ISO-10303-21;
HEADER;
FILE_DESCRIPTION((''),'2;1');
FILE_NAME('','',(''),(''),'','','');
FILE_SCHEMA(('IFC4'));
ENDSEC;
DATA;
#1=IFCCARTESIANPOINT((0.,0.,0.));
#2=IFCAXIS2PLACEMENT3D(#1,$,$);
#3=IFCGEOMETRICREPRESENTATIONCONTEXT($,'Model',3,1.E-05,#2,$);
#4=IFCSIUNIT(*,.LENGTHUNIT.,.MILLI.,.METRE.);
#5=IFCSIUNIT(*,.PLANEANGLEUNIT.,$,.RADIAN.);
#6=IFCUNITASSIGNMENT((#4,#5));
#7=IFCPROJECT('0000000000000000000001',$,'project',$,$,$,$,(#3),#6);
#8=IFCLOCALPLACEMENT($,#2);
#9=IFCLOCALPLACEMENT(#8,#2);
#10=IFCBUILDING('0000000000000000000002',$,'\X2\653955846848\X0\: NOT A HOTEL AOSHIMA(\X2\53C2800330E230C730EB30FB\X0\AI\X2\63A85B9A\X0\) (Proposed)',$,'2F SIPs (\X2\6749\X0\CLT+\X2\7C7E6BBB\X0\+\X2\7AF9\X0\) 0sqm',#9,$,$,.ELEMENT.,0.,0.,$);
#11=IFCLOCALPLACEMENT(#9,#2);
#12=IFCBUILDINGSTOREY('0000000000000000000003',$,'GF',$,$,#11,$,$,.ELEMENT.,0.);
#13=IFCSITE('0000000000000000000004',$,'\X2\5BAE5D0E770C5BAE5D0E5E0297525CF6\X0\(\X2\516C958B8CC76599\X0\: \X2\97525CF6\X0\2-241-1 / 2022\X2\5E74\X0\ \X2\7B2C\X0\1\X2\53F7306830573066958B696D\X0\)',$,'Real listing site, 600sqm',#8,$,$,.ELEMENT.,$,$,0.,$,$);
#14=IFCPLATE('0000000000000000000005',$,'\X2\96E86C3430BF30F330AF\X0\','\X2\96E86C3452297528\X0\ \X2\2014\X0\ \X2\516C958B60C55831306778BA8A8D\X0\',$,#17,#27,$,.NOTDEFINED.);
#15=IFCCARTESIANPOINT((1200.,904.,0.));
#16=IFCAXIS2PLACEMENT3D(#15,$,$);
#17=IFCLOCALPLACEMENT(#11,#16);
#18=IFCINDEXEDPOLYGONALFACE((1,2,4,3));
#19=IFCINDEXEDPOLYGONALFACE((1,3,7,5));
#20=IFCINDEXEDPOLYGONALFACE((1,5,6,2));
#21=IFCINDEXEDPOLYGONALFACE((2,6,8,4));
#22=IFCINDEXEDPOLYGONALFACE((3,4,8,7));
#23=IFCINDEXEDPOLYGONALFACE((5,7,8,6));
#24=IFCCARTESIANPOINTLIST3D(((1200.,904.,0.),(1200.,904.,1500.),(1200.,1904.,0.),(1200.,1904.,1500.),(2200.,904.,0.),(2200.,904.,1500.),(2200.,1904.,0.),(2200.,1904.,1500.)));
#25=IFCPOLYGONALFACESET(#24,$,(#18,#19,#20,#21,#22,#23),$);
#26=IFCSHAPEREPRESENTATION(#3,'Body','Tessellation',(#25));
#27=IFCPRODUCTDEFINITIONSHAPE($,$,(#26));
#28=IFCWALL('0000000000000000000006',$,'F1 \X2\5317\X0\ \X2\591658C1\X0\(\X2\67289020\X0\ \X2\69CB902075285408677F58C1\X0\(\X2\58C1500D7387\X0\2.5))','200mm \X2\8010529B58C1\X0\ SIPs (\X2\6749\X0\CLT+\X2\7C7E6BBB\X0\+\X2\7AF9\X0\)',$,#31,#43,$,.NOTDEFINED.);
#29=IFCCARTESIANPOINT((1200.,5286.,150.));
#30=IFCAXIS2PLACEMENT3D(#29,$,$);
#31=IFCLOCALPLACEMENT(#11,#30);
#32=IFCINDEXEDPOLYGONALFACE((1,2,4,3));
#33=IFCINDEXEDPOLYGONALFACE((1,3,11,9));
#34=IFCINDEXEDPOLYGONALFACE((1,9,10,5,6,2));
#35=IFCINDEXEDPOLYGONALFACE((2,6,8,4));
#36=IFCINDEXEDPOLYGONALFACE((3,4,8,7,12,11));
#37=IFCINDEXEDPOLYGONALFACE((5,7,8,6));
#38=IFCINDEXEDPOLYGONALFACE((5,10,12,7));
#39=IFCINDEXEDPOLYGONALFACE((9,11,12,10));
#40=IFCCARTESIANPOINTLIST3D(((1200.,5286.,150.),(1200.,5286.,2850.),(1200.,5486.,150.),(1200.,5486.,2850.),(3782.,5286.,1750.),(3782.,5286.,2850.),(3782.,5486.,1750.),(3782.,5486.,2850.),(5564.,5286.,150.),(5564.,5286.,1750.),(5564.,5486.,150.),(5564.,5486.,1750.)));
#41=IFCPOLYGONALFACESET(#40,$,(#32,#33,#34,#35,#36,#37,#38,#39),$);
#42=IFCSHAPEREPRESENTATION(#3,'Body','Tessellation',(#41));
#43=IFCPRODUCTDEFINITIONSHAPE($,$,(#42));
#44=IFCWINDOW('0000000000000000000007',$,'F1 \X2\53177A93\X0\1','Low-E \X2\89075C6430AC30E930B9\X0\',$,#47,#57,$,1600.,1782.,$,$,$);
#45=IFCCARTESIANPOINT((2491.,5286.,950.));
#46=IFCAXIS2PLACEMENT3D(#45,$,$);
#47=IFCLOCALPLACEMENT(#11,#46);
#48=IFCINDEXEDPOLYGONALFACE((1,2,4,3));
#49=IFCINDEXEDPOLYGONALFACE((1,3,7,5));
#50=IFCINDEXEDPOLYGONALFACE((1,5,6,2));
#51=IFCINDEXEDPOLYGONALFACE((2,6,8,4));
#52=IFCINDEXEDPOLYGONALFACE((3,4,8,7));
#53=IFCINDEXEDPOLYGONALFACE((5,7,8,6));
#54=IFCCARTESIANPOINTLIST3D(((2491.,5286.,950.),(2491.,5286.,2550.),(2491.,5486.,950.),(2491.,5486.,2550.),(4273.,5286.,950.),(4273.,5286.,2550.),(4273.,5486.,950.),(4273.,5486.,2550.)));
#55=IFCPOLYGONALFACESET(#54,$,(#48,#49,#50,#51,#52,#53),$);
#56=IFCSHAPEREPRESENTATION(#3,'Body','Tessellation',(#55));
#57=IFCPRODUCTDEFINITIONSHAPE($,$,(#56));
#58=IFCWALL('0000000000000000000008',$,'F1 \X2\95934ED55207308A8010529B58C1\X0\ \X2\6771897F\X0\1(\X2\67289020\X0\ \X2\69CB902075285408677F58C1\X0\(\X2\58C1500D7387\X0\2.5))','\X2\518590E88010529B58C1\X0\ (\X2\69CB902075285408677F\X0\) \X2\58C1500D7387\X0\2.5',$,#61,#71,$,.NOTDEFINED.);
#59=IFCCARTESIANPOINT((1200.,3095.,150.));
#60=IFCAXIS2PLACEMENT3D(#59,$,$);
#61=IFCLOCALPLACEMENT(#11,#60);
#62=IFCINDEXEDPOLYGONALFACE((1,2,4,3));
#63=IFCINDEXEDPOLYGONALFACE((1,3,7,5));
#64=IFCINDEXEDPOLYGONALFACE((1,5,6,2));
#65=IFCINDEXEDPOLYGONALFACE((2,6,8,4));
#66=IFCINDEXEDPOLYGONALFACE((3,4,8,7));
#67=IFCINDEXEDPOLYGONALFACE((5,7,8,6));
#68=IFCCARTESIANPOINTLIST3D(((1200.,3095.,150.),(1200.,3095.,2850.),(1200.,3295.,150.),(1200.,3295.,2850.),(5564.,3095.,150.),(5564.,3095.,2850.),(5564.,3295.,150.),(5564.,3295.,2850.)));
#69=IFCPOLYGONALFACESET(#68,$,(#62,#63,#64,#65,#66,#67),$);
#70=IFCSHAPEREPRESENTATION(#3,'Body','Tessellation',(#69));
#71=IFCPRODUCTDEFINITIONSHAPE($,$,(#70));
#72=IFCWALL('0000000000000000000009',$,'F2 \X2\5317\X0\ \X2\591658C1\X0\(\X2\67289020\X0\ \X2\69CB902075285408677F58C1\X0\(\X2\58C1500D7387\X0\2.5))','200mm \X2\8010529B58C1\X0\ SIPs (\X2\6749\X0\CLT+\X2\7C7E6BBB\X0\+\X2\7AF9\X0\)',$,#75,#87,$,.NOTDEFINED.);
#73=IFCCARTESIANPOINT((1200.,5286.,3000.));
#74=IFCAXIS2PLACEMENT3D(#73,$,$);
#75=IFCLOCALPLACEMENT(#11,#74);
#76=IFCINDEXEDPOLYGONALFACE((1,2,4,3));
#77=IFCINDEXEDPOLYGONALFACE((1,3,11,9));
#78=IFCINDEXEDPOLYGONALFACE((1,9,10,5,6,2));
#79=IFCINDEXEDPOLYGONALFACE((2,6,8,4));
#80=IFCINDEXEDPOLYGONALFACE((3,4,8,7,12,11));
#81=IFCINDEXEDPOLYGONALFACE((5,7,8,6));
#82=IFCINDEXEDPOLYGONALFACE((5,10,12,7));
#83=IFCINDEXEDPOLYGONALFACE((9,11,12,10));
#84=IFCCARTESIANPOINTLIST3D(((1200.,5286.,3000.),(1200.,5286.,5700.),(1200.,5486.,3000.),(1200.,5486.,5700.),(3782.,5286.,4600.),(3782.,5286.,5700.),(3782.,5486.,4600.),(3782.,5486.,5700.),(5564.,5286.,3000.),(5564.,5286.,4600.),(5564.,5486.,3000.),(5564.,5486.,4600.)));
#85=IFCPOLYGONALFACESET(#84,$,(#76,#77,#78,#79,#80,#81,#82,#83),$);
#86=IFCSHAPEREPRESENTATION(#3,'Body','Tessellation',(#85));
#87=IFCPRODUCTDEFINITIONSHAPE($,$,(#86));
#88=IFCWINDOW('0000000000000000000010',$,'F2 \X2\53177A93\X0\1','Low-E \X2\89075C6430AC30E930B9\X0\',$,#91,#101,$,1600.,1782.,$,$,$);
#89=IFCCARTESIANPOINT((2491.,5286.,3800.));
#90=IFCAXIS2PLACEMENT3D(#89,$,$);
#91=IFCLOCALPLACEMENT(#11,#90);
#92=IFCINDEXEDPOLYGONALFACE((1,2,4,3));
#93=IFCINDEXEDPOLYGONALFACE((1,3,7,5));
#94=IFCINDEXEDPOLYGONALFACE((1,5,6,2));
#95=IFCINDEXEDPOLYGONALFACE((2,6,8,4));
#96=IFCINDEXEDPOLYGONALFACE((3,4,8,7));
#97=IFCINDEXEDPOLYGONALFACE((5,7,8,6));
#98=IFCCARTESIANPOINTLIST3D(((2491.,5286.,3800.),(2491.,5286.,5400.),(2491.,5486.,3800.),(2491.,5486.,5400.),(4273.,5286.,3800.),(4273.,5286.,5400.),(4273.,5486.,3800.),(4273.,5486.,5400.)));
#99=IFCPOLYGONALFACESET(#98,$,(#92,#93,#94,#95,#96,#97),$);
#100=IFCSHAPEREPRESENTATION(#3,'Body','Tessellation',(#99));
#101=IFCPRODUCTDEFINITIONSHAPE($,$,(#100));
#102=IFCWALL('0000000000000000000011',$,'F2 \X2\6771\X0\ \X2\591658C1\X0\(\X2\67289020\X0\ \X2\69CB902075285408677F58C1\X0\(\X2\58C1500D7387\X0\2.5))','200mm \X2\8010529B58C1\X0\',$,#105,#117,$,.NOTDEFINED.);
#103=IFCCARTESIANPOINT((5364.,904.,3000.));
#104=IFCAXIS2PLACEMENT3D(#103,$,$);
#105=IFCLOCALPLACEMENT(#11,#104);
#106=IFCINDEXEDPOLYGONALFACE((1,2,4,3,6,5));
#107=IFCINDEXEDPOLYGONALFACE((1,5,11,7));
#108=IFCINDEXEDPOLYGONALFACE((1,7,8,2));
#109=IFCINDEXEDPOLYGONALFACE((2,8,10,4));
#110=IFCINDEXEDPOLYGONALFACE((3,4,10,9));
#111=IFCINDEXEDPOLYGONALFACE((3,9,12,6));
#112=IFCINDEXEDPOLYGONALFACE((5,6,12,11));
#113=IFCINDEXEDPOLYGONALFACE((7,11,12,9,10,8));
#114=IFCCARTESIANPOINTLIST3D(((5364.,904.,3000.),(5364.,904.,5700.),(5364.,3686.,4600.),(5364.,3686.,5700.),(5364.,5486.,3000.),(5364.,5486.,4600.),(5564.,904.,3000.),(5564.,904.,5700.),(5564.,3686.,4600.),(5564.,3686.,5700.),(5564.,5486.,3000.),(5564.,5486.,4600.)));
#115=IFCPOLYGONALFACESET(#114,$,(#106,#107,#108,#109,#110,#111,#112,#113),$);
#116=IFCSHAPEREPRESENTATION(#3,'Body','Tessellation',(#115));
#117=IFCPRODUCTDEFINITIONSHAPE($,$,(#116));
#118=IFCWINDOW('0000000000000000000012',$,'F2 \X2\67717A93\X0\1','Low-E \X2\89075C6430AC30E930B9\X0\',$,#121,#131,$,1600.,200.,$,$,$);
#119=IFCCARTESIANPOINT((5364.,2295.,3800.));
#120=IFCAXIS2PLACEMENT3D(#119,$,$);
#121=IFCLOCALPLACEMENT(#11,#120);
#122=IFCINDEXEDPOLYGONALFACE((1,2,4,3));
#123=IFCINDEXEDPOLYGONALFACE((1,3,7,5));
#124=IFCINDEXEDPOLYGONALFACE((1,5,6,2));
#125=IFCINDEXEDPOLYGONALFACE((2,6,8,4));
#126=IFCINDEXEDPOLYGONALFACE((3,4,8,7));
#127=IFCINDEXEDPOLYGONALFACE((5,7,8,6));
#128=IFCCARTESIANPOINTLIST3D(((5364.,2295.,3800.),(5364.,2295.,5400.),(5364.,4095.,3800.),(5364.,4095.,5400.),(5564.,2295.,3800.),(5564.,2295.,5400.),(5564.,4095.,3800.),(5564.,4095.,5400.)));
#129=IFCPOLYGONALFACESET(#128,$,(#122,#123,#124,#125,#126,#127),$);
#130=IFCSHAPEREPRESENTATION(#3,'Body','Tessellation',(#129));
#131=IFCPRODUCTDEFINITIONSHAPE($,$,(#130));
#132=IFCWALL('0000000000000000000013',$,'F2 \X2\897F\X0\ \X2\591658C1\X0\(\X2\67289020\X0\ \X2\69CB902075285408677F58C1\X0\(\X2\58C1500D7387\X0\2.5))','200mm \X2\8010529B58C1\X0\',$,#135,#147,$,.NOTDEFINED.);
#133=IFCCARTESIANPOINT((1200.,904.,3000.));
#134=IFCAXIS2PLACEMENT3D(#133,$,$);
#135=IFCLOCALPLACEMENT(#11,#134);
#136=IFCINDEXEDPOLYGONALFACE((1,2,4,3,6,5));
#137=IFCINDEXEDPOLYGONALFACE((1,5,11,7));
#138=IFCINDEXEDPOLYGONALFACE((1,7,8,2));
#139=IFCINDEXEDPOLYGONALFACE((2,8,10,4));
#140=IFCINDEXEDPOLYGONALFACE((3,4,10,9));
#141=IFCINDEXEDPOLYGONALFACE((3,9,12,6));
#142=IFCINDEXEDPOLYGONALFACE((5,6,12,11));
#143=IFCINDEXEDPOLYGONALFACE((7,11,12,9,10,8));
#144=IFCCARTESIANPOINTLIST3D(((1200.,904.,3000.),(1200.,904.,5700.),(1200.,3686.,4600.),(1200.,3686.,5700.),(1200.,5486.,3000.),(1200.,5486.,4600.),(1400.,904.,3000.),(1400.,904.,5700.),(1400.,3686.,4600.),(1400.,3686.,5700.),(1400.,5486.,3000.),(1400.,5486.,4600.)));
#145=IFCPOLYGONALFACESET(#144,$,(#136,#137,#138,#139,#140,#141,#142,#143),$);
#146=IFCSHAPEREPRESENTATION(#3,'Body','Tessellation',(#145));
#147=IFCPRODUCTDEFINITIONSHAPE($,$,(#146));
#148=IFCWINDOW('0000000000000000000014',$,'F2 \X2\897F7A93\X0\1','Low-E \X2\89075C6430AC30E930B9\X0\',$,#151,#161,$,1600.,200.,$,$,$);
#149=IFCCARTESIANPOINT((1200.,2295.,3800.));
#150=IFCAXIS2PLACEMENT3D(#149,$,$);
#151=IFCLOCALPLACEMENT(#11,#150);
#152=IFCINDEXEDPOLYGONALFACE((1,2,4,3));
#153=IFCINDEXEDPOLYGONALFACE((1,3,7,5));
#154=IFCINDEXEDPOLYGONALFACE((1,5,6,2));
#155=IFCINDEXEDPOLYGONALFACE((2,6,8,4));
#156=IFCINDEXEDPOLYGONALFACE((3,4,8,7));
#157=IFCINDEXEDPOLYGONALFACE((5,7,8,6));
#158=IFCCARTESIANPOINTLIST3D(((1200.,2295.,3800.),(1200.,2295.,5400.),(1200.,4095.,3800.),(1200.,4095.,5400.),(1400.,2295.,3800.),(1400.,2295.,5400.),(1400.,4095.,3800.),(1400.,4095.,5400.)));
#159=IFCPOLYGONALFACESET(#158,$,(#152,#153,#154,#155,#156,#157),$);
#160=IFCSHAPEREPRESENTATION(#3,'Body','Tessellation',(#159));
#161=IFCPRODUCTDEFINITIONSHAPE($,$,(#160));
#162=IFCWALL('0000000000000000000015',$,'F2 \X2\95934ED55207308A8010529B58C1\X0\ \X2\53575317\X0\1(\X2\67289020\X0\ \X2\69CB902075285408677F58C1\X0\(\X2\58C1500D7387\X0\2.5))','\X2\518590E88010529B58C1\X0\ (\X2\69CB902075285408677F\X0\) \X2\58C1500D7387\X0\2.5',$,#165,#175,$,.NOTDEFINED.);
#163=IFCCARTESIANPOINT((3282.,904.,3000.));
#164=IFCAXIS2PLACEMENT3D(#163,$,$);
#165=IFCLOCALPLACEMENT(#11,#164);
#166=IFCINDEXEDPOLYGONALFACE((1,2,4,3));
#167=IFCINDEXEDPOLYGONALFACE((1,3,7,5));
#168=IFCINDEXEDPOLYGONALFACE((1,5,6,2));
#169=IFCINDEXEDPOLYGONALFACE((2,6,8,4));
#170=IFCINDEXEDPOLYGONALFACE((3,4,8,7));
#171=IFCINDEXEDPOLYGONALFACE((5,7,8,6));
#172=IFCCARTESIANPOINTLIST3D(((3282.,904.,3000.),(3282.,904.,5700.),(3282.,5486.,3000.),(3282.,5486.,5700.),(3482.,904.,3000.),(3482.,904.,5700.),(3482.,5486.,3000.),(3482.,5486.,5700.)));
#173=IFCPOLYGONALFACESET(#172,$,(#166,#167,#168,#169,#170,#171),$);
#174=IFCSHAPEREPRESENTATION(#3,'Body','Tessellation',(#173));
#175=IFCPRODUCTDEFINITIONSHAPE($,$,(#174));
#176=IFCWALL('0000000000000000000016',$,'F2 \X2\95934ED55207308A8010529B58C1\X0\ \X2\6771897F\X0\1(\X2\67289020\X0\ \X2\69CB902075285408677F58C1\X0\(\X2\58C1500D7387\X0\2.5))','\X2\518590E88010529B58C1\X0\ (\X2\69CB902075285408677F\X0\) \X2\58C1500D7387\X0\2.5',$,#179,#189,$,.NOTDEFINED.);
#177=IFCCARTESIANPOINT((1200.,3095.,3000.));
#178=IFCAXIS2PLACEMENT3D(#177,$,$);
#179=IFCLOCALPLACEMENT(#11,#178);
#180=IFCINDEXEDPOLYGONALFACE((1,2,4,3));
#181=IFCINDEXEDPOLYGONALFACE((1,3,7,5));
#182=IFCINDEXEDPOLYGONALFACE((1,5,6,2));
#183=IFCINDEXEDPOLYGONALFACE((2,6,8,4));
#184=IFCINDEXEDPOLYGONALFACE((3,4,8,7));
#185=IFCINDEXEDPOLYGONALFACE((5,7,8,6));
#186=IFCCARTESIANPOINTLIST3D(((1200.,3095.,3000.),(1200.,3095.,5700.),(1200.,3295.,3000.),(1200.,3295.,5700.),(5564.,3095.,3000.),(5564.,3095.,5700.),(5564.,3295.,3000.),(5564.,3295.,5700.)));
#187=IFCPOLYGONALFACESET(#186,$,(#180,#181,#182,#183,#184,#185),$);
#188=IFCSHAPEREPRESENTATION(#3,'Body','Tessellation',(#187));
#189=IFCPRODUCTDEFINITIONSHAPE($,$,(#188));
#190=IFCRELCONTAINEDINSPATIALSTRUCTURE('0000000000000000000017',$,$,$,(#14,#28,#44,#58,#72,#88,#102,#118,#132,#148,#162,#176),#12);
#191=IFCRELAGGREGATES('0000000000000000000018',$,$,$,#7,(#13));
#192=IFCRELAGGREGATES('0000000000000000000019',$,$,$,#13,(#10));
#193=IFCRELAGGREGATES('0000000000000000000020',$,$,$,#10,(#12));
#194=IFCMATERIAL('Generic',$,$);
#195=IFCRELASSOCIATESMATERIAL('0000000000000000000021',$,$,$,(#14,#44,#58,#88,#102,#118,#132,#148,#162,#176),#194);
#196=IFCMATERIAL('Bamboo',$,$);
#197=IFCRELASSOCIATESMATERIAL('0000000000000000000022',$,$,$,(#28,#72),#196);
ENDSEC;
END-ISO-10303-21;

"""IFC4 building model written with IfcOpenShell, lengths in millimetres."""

from ifc_helpers import new_model, si_unit, frame, frame_2d, origin, place, context, project, spatial, rectangle, extrude, material, element, fill, save


model = new_model("IFC4")

# Units and contexts
model_context = context("Model", 3, precision=1e-05, world=origin())
ifc_project = project(units=[si_unit("LENGTHUNIT", "METRE", prefix="MILLI"), si_unit("PLANEANGLEUNIT", "RADIAN")], contexts=[model_context])

# Site, building, storey
site_placement = place(None, origin())
site = spatial("IfcSite", under=ifc_project, at=site_placement, Name="宮崎県宮崎市青島(公開資料: 青島2-241-1 / 2022年 第1号として開業)", ObjectType="Real listing site, 600sqm", CompositionType="ELEMENT", RefElevation=0.0)
building_placement = place(site_placement, origin())
building = spatial("IfcBuilding", under=site, at=building_placement, Name="改善案: NOT A HOTEL AOSHIMA(参考モデル・AI推定) (Proposed)", ObjectType="2F SIPs (杉CLT+籾殻+竹) 0sqm", CompositionType="ELEMENT", ElevationOfRefHeight=0.0, ElevationOfTerrain=0.0)
storey_placement = place(building_placement, origin())
storey = spatial("IfcBuildingStorey", under=building, at=storey_placement, Name="GF", CompositionType="ELEMENT", Elevation=0.0)

# Plate
ifc_material_1 = material(Name="Generic")
plate_placement = place(storey_placement, frame((1200.0, 904.0, 0.0)))
element("IfcPlate", 1, at=plate_placement, inside=storey, material=ifc_material_1, Name="雨水タンク", Description="雨水利用 — 公開情報で確認", PredefinedType="NOTDEFINED", context=model_context, shape_type="SweptSolid", body=[
    extrude(rectangle(XDim=1000.0, YDim=1000.0, at=frame_2d((500.0, 500.0))), frame((1200.0, 904.0, 0.0)), (0.0, 0.0, 1.0), 1500.0),
])

# Wall, opening, window
ifc_material_2 = material(Name="Bamboo")
wall_1_placement = place(storey_placement, frame((1200.0, 5286.0, 150.0)))
wall_1 = element("IfcWall", 2, at=wall_1_placement, inside=storey, material=ifc_material_2, Name="F1 北 外壁(木造 構造用合板壁(壁倍率2.5))", Description="200mm 耐力壁 SIPs (杉CLT+籾殻+竹)", PredefinedType="NOTDEFINED", context=model_context, shape_type="SweptSolid", body=[
    extrude(rectangle(XDim=4364.0, YDim=200.0, at=frame_2d((2182.0, 100.0))), frame((1200.0, 5286.0, 150.0)), (0.0, 0.0, 1.0), 2700.0),
])
opening_1_placement = place(storey_placement, frame((2491.0, 5286.0, 950.0)))
opening_1 = element("IfcOpeningElement", 3, at=opening_1_placement, cuts=wall_1, PredefinedType="NOTDEFINED", context=model_context, shape_type="SweptSolid", body=[
    extrude(rectangle(XDim=1782.0, YDim=200.0, at=frame_2d((891.0, 100.0))), frame((2491.0, 5286.0, 950.0)), (0.0, 0.0, 1.0), 1600.0),
])
window_1_placement = place(storey_placement, frame((2491.0, 5286.0, 950.0)))
window_1 = element("IfcWindow", 4, at=window_1_placement, inside=storey, material=ifc_material_1, Name="F1 北窓1", Description="Low-E 複層ガラス", OverallHeight=1600.0, OverallWidth=1782.0, context=model_context, shape_type="SweptSolid", body=[
    extrude(rectangle(XDim=1782.0, YDim=200.0, at=frame_2d((891.0, 100.0))), frame((2491.0, 5286.0, 950.0)), (0.0, 0.0, 1.0), 1600.0),
])
fill(opening_1, window_1)

# Wall
wall_2_placement = place(storey_placement, frame((1200.0, 3095.0, 150.0)))
element("IfcWall", 5, at=wall_2_placement, inside=storey, material=ifc_material_1, Name="F1 間仕切り耐力壁 東西1(木造 構造用合板壁(壁倍率2.5))", Description="内部耐力壁 (構造用合板) 壁倍率2.5", PredefinedType="NOTDEFINED", context=model_context, shape_type="SweptSolid", body=[
    extrude(rectangle(XDim=4364.0, YDim=200.0, at=frame_2d((2182.0, 100.0))), frame((1200.0, 3095.0, 150.0)), (0.0, 0.0, 1.0), 2700.0),
])

# Walls, openings, windows
wall_3_placement = place(storey_placement, frame((1200.0, 5286.0, 3000.0)))
wall_3 = element("IfcWall", 6, at=wall_3_placement, inside=storey, material=ifc_material_2, Name="F2 北 外壁(木造 構造用合板壁(壁倍率2.5))", Description="200mm 耐力壁 SIPs (杉CLT+籾殻+竹)", PredefinedType="NOTDEFINED", context=model_context, shape_type="SweptSolid", body=[
    extrude(rectangle(XDim=4364.0, YDim=200.0, at=frame_2d((2182.0, 100.0))), frame((1200.0, 5286.0, 3000.0)), (0.0, 0.0, 1.0), 2700.0),
])
opening_2_placement = place(storey_placement, frame((2491.0, 5286.0, 3800.0)))
opening_2 = element("IfcOpeningElement", 7, at=opening_2_placement, cuts=wall_3, PredefinedType="NOTDEFINED", context=model_context, shape_type="SweptSolid", body=[
    extrude(rectangle(XDim=1782.0, YDim=200.0, at=frame_2d((891.0, 100.0))), frame((2491.0, 5286.0, 3800.0)), (0.0, 0.0, 1.0), 1600.0),
])
window_2_placement = place(storey_placement, frame((2491.0, 5286.0, 3800.0)))
window_2 = element("IfcWindow", 8, at=window_2_placement, inside=storey, material=ifc_material_1, Name="F2 北窓1", Description="Low-E 複層ガラス", OverallHeight=1600.0, OverallWidth=1782.0, context=model_context, shape_type="SweptSolid", body=[
    extrude(rectangle(XDim=1782.0, YDim=200.0, at=frame_2d((891.0, 100.0))), frame((2491.0, 5286.0, 3800.0)), (0.0, 0.0, 1.0), 1600.0),
])
fill(opening_2, window_2)
wall_4_placement = place(storey_placement, frame((5364.0, 904.0, 3000.0)))
wall_4 = element("IfcWall", 9, at=wall_4_placement, inside=storey, material=ifc_material_1, Name="F2 東 外壁(木造 構造用合板壁(壁倍率2.5))", Description="200mm 耐力壁", PredefinedType="NOTDEFINED", context=model_context, shape_type="SweptSolid", body=[
    extrude(rectangle(XDim=200.0, YDim=4582.0, at=frame_2d((100.0, 2291.0))), frame((5364.0, 904.0, 3000.0)), (0.0, 0.0, 1.0), 2700.0),
])
opening_3_placement = place(storey_placement, frame((5364.0, 2295.0, 3800.0)))
opening_3 = element("IfcOpeningElement", 10, at=opening_3_placement, cuts=wall_4, PredefinedType="NOTDEFINED", context=model_context, shape_type="SweptSolid", body=[
    extrude(rectangle(XDim=200.0, YDim=1800.0, at=frame_2d((100.0, 900.0))), frame((5364.0, 2295.0, 3800.0)), (0.0, 0.0, 1.0), 1600.0),
])
window_3_placement = place(storey_placement, frame((5364.0, 2295.0, 3800.0)))
window_3 = element("IfcWindow", 11, at=window_3_placement, inside=storey, material=ifc_material_1, Name="F2 東窓1", Description="Low-E 複層ガラス", OverallHeight=1600.0, OverallWidth=200.0, context=model_context, shape_type="SweptSolid", body=[
    extrude(rectangle(XDim=200.0, YDim=1800.0, at=frame_2d((100.0, 900.0))), frame((5364.0, 2295.0, 3800.0)), (0.0, 0.0, 1.0), 1600.0),
])
fill(opening_3, window_3)
wall_5_placement = place(storey_placement, frame((1200.0, 904.0, 3000.0)))
wall_5 = element("IfcWall", 12, at=wall_5_placement, inside=storey, material=ifc_material_1, Name="F2 西 外壁(木造 構造用合板壁(壁倍率2.5))", Description="200mm 耐力壁", PredefinedType="NOTDEFINED", context=model_context, shape_type="SweptSolid", body=[
    extrude(rectangle(XDim=200.0, YDim=4582.0, at=frame_2d((100.0, 2291.0))), frame((1200.0, 904.0, 3000.0)), (0.0, 0.0, 1.0), 2700.0),
])
opening_4_placement = place(storey_placement, frame((1200.0, 2295.0, 3800.0)))
opening_4 = element("IfcOpeningElement", 13, at=opening_4_placement, cuts=wall_5, PredefinedType="NOTDEFINED", context=model_context, shape_type="SweptSolid", body=[
    extrude(rectangle(XDim=200.0, YDim=1800.0, at=frame_2d((100.0, 900.0))), frame((1200.0, 2295.0, 3800.0)), (0.0, 0.0, 1.0), 1600.0),
])
window_4_placement = place(storey_placement, frame((1200.0, 2295.0, 3800.0)))
window_4 = element("IfcWindow", 14, at=window_4_placement, inside=storey, material=ifc_material_1, Name="F2 西窓1", Description="Low-E 複層ガラス", OverallHeight=1600.0, OverallWidth=200.0, context=model_context, shape_type="SweptSolid", body=[
    extrude(rectangle(XDim=200.0, YDim=1800.0, at=frame_2d((100.0, 900.0))), frame((1200.0, 2295.0, 3800.0)), (0.0, 0.0, 1.0), 1600.0),
])
fill(opening_4, window_4)

# Walls
wall_6_placement = place(storey_placement, frame((3282.0, 904.0, 3000.0)))
element("IfcWall", 15, at=wall_6_placement, inside=storey, material=ifc_material_1, Name="F2 間仕切り耐力壁 南北1(木造 構造用合板壁(壁倍率2.5))", Description="内部耐力壁 (構造用合板) 壁倍率2.5", PredefinedType="NOTDEFINED", context=model_context, shape_type="SweptSolid", body=[
    extrude(rectangle(XDim=200.0, YDim=4582.0, at=frame_2d((100.0, 2291.0))), frame((3282.0, 904.0, 3000.0)), (0.0, 0.0, 1.0), 2700.0),
])
wall_7_placement = place(storey_placement, frame((1200.0, 3095.0, 3000.0)))
element("IfcWall", 16, at=wall_7_placement, inside=storey, material=ifc_material_1, Name="F2 間仕切り耐力壁 東西1(木造 構造用合板壁(壁倍率2.5))", Description="内部耐力壁 (構造用合板) 壁倍率2.5", PredefinedType="NOTDEFINED", context=model_context, shape_type="SweptSolid", body=[
    extrude(rectangle(XDim=4364.0, YDim=200.0, at=frame_2d((2182.0, 100.0))), frame((1200.0, 3095.0, 3000.0)), (0.0, 0.0, 1.0), 2700.0),
])

save(model, "model.ifc")
